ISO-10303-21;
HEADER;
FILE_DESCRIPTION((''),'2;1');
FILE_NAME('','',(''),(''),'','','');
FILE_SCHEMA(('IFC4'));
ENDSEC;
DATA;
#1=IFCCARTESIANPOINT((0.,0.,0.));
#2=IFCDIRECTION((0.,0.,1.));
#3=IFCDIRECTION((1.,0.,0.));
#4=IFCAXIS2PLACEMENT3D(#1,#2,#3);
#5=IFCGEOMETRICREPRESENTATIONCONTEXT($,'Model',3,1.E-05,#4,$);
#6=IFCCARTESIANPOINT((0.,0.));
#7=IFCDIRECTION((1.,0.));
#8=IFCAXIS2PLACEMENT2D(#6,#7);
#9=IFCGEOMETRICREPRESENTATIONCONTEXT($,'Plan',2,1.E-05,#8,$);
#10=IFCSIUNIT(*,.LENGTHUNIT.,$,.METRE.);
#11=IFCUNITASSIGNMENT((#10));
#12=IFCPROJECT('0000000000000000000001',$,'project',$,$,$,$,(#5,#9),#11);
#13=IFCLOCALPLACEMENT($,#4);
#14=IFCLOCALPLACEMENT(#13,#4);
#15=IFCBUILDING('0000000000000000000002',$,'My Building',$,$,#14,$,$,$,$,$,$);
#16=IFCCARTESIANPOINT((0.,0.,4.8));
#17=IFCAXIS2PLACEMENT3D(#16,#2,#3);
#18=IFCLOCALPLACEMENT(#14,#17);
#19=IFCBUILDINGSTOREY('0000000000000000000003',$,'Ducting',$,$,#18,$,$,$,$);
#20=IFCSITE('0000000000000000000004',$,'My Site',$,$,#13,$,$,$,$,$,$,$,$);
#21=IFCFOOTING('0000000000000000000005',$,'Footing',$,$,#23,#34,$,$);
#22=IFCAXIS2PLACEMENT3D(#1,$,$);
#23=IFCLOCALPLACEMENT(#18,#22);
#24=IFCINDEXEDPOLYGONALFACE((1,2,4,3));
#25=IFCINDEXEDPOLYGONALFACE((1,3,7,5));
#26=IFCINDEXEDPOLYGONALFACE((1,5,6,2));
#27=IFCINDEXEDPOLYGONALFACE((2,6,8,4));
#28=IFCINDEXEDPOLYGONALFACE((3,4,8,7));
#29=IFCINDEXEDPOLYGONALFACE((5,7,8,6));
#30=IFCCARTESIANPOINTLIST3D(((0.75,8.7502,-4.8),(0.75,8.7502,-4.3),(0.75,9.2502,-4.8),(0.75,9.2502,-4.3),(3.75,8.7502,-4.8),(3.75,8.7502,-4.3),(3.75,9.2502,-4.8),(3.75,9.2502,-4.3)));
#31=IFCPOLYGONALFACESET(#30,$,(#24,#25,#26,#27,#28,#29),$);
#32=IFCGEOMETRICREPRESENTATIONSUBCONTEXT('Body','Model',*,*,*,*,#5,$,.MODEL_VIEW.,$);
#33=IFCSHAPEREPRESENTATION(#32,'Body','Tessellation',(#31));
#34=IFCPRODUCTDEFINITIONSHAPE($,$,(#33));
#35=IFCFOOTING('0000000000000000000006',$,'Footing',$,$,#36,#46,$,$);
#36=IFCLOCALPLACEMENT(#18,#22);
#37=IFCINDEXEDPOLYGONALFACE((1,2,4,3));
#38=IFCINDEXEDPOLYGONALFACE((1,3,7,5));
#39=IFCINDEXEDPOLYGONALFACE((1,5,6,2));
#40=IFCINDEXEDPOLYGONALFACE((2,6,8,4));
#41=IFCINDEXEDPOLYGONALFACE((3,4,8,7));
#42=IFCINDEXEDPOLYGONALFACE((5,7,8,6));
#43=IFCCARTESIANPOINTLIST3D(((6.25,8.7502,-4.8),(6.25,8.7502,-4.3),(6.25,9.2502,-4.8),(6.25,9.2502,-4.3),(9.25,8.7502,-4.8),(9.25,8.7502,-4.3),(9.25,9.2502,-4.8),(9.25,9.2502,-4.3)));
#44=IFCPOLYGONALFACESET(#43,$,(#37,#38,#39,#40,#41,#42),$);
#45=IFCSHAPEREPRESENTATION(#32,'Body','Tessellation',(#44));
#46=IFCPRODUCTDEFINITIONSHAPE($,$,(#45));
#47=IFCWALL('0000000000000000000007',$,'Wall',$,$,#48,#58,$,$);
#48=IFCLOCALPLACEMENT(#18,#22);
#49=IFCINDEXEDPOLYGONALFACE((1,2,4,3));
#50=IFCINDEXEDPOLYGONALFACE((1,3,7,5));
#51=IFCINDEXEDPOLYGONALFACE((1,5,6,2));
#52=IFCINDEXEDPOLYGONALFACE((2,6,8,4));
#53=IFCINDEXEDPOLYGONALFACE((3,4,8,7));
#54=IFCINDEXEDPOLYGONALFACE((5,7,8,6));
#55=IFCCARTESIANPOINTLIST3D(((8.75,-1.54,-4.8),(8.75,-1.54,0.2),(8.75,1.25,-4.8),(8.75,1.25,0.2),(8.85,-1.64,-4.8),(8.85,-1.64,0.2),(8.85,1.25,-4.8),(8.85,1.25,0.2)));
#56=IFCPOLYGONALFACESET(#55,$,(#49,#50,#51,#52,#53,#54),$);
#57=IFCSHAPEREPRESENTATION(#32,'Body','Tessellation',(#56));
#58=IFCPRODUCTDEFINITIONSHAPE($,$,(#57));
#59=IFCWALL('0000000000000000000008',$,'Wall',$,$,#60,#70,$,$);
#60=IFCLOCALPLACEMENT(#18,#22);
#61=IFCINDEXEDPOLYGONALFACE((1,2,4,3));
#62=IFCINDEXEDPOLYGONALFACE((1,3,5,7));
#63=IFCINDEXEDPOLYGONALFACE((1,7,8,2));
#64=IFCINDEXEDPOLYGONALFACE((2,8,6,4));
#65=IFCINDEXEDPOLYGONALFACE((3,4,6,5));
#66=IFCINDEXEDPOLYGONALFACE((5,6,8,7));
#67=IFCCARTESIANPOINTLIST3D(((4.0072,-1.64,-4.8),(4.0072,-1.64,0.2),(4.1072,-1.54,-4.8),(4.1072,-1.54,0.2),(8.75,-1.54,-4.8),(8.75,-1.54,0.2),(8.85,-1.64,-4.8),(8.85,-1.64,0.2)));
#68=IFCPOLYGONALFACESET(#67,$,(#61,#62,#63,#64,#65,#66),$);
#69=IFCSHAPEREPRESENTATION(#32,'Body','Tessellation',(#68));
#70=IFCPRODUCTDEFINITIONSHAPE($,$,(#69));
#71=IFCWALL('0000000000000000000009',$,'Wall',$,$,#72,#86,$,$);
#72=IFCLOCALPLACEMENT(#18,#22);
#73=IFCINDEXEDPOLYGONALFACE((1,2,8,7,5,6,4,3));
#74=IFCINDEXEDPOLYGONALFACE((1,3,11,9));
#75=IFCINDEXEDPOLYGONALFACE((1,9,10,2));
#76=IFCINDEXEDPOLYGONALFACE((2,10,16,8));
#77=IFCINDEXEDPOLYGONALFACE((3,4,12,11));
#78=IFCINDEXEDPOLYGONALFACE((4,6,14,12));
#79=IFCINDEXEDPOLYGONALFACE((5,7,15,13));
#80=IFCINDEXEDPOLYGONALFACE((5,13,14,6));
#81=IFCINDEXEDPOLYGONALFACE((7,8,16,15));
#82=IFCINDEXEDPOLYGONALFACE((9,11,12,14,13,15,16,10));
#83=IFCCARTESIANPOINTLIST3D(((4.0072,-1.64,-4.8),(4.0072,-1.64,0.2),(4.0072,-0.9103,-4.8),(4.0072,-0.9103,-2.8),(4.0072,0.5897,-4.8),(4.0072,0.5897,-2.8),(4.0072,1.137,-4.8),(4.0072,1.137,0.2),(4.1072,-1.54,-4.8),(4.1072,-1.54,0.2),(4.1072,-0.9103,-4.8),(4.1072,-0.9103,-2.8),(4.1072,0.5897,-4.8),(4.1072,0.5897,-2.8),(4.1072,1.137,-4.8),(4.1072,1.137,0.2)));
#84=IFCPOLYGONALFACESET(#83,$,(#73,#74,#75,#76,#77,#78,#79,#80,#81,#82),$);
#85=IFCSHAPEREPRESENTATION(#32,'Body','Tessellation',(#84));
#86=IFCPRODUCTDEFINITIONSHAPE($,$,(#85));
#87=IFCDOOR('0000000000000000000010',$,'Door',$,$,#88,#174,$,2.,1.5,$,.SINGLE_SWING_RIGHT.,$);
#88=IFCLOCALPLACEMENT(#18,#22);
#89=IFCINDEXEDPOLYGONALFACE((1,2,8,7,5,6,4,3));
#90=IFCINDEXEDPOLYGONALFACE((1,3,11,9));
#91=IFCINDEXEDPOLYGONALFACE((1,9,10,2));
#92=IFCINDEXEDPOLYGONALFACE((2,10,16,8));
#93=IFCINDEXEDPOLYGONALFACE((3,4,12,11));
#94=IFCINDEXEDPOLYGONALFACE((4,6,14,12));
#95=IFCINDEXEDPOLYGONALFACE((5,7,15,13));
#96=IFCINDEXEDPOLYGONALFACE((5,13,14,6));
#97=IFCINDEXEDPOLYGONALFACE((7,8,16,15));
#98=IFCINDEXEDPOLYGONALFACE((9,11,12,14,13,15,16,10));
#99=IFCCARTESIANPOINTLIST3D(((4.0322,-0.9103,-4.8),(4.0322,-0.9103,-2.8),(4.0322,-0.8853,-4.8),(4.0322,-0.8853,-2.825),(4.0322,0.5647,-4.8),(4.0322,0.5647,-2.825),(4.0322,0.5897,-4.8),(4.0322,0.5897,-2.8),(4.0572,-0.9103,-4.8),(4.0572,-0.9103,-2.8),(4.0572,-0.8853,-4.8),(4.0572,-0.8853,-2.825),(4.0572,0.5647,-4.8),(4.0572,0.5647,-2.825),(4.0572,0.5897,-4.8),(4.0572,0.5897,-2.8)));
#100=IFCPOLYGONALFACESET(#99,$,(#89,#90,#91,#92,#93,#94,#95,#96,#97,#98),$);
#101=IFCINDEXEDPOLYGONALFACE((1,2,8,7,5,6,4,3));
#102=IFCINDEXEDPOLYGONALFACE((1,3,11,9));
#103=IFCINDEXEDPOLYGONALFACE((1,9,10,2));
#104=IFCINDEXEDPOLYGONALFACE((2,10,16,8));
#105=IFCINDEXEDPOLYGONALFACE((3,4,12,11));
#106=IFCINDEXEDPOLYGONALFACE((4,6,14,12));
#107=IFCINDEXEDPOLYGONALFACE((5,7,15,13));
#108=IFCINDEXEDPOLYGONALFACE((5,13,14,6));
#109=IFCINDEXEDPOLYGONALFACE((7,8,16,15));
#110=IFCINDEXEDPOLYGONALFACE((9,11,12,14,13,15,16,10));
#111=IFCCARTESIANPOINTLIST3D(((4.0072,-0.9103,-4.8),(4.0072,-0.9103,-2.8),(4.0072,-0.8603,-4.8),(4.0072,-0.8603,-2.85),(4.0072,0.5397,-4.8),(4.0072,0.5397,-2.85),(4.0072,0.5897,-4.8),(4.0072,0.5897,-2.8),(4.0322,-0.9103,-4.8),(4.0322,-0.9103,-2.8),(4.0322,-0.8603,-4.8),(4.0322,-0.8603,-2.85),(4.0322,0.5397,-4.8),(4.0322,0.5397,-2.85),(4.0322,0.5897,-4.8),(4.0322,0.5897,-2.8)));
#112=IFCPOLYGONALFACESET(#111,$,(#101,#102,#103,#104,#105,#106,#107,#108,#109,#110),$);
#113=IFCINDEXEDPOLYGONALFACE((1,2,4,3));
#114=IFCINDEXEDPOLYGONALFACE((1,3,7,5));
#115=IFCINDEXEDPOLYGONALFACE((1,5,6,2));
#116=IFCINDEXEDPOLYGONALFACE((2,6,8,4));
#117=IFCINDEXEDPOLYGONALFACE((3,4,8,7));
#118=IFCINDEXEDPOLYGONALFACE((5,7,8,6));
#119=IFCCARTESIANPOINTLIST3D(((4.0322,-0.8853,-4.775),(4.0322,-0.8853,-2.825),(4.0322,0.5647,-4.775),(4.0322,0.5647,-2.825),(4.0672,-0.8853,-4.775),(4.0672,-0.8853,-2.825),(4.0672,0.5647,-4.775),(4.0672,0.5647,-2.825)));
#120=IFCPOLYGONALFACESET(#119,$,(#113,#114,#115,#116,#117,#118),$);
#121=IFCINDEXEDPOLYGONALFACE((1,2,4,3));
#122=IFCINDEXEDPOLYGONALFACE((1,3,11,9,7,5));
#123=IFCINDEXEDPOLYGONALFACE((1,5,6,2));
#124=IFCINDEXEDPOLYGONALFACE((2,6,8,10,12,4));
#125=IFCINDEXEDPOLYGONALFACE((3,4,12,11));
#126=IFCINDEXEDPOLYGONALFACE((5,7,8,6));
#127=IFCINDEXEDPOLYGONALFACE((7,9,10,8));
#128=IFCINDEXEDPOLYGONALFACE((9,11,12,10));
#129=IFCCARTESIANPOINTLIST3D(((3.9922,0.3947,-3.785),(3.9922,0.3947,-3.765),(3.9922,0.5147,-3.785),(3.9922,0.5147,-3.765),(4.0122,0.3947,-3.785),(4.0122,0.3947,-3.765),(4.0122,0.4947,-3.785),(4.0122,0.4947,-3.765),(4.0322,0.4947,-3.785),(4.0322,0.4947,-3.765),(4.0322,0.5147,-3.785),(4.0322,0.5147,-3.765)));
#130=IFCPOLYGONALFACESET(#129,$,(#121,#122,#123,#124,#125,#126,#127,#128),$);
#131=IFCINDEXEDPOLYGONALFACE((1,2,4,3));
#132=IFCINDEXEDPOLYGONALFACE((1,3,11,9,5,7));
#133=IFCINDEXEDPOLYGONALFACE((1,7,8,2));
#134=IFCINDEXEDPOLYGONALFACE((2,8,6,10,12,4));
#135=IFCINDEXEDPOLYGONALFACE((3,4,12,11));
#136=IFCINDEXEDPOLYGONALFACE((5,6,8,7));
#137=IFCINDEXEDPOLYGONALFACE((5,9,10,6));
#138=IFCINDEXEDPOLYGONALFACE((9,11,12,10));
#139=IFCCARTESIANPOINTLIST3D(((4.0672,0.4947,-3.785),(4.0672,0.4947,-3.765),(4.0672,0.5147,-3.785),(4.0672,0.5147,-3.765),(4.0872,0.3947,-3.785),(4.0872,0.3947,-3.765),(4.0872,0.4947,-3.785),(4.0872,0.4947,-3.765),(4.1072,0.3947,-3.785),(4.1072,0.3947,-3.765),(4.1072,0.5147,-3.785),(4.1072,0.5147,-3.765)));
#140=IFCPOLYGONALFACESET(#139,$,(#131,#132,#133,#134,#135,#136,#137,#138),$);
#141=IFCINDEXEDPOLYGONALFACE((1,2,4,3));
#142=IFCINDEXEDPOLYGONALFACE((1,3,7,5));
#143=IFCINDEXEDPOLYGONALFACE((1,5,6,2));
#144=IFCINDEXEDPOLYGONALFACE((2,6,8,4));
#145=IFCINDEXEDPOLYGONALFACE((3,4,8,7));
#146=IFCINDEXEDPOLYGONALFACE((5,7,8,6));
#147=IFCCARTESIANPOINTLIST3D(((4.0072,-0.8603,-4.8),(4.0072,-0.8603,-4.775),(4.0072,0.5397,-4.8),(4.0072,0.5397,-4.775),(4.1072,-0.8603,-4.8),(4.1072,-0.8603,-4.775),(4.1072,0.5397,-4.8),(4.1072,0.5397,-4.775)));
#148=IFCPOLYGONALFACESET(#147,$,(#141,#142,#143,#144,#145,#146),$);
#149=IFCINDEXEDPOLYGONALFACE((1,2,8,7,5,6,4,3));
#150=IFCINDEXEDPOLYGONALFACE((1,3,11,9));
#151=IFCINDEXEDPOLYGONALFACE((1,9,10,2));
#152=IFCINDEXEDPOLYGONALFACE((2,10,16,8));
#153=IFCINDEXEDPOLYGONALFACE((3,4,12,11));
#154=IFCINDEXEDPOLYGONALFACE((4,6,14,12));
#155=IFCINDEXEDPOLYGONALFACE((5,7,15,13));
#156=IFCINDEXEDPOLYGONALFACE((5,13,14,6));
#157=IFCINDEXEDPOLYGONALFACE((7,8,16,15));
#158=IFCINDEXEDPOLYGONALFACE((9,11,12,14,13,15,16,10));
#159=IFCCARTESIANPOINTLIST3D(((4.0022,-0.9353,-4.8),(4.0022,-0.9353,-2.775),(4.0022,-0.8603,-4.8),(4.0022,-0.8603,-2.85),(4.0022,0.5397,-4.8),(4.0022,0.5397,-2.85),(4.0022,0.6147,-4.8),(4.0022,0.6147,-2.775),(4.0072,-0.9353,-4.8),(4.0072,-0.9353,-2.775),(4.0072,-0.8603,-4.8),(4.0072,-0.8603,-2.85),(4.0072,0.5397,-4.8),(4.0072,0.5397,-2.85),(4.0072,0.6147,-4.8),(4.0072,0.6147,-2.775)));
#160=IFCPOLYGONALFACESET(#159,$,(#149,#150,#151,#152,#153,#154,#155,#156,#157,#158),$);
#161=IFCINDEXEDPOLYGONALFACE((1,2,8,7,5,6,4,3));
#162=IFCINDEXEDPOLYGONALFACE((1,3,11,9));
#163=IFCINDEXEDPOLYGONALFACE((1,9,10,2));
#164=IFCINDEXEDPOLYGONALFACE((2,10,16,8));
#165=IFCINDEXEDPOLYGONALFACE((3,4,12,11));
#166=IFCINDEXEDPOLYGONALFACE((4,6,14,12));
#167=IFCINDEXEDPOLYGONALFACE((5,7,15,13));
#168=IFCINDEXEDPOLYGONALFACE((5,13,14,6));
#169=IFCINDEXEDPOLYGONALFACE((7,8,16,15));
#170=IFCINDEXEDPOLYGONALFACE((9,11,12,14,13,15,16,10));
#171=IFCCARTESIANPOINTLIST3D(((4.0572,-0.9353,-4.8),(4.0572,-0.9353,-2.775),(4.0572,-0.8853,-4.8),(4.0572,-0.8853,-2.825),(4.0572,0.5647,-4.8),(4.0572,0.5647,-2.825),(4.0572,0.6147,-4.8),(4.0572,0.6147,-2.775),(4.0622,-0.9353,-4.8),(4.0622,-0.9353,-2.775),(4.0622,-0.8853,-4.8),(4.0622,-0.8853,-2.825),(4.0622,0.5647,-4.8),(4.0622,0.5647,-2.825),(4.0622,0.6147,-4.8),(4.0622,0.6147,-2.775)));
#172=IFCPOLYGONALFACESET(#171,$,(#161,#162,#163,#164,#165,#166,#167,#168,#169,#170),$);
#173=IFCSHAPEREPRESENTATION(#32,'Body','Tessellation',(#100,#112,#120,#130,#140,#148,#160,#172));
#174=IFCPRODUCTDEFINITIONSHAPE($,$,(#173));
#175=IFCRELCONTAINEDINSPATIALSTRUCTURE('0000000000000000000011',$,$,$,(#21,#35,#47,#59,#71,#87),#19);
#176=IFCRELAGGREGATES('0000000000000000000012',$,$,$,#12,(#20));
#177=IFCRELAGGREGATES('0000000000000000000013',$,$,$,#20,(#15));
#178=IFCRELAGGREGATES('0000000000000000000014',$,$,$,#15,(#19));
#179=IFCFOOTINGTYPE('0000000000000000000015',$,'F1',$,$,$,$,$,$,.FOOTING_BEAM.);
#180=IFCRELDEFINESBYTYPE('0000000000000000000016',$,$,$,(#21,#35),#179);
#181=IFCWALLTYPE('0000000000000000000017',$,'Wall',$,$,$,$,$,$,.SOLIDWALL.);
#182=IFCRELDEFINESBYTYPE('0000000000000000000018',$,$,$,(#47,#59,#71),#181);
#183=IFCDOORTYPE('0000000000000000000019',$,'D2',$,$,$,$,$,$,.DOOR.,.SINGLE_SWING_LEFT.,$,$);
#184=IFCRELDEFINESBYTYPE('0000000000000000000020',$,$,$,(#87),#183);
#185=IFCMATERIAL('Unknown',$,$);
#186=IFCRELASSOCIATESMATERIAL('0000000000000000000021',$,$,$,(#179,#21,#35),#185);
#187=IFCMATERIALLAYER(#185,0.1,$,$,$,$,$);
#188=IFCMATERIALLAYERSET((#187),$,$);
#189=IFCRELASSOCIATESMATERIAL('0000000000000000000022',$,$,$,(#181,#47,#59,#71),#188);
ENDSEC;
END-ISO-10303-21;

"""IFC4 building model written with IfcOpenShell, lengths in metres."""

from ifc_helpers import new_model, entity, si_unit, frame, origin_with_axes, origin_2d_with_axis, place, context, subcontext, project, spatial, line, indexed_curve, rectangle, outline, extrude, shape, source, transform, mapped, material, layer, layer_set, layer_usage, material_profile, profile_set, profile_usage, type_object, type_shapes, element, fill, save


model = new_model("IFC4")

# Units and contexts
model_context = context("Model", 3, precision=1e-05, world=origin_with_axes())
plan_context = context("Plan", 2, precision=1e-05, world=origin_2d_with_axis())
body_context_1 = subcontext(model_context, "Body", "Model", "MODEL_VIEW")
body_context_2 = subcontext(plan_context, "Body", "Plan", "PLAN_VIEW")
ifc_project = project(units=[si_unit("LENGTHUNIT", "METRE")], contexts=[model_context, plan_context])

# Site, building, storey
site_placement = place(None, origin_with_axes())
site = spatial("IfcSite", under=ifc_project, at=site_placement, Name="My Site")
building_placement = place(site_placement, origin_with_axes())
building = spatial("IfcBuilding", under=site, at=building_placement, Name="My Building")
storey_placement = place(building_placement, frame((0.0, 0.0, 4.8), z_axis=(0.0, 0.0, 1.0), x_axis=(1.0, 0.0, 0.0)))
storey = spatial("IfcBuildingStorey", under=building, at=storey_placement, Name="Ducting")

# Footings
ifc_material = material(Name="Unknown")
ifc_material_profile_1 = material_profile(ifc_material, rectangle(XDim=0.5, YDim=0.5))
ifc_profile_set_1 = profile_set([ifc_material_profile_1])
ifc_profile_usage_1 = profile_usage(ifc_profile_set_1, cardinal=5)
footing_type = type_object("IfcFootingType", Name="F1", PredefinedType="FOOTING_BEAM", material=ifc_profile_set_1)
footing_1_placement = place(storey_placement, frame((0.75, 9.0002, -4.55), z_axis=(1.0, 0.0, 0.0), x_axis=(0.0, 1.0, 0.0)))
element("IfcFooting", 1, at=footing_1_placement, inside=storey, type_object=footing_type, material=ifc_profile_usage_1, Name="Footing", context=body_context_1, shape_type="SweptSolid", body=[
    extrude(rectangle(XDim=0.5, YDim=0.5), origin_with_axes(), (0.0, 0.0, 1.0), 3.0),
])
ifc_profile_usage_2 = profile_usage(ifc_profile_set_1, cardinal=5)
footing_2_placement = place(storey_placement, frame((6.25, 9.0002, -4.55), z_axis=(1.0, 0.0, 0.0), x_axis=(0.0, 1.0, 0.0)))
element("IfcFooting", 2, at=footing_2_placement, inside=storey, type_object=footing_type, material=ifc_profile_usage_2, Name="Footing", context=body_context_1, shape_type="SweptSolid", body=[
    extrude(rectangle(XDim=0.5, YDim=0.5), origin_with_axes(), (0.0, 0.0, 1.0), 3.0),
])

# Walls
ifc_layer = layer(ifc_material, 0.1)
ifc_layer_set = layer_set([ifc_layer])
ifc_layer_usage_1 = layer_usage(ifc_layer_set, "AXIS2", "POSITIVE", 0.0)
wall_type = type_object("IfcWallType", Name="Wall", PredefinedType="SOLIDWALL", material=ifc_layer_set)
wall_1_placement = place(storey_placement, frame((8.75, 1.25, -4.8), z_axis=(0.0, 0.0, 1.0), x_axis=(0.0, -1.0, 0.0)))
element("IfcWall", 3, at=wall_1_placement, inside=storey, type_object=wall_type, material=ifc_layer_usage_1, Name="Wall", context=body_context_1, shape_type="SweptSolid", body=[
    extrude(outline(indexed_curve([(0.0, 0.0), (0.0, 0.1), (2.89, 0.1), (2.79, 0.0)], segments=[line(1, 2, 3, 4, 1)])), origin_with_axes(), (0.0, 0.0, 1.0), 5.0),
])
ifc_layer_usage_2 = layer_usage(ifc_layer_set, "AXIS2", "POSITIVE", 0.0)
wall_2_placement = place(storey_placement, frame((8.75, -1.54, -4.8), z_axis=(0.0, 0.0, 1.0), x_axis=(-1.0, 0.0, 0.0)))
element("IfcWall", 4, at=wall_2_placement, inside=storey, type_object=wall_type, material=ifc_layer_usage_2, Name="Wall", context=body_context_1, shape_type="SweptSolid", body=[
    extrude(outline(indexed_curve([(0.0, 0.0), (-0.1, 0.1), (4.7428, 0.1), (4.6428, 0.0)], segments=[line(1, 2, 3, 4, 1)])), origin_with_axes(), (0.0, 0.0, 1.0), 5.0),
])

# Wall, opening, door
ifc_layer_usage_3 = layer_usage(ifc_layer_set, "AXIS2", "POSITIVE", 0.0)
wall_3_placement = place(storey_placement, frame((4.1072, -1.54, -4.8), z_axis=(0.0, 0.0, 1.0), x_axis=(0.0, 1.0, 0.0)))
wall_3 = element("IfcWall", 5, at=wall_3_placement, inside=storey, type_object=wall_type, material=ifc_layer_usage_3, Name="Wall", context=body_context_1, shape_type="SweptSolid", body=[
    extrude(outline(indexed_curve([(0.0, 0.0), (-0.1, 0.1), (2.677, 0.1), (2.677, 0.0)], segments=[line(1, 2, 3, 4, 1)])), origin_with_axes(), (0.0, 0.0, 1.0), 5.0),
])
shared_shape_1 = source(origin_with_axes(), body_context_1, "Body", "SweptSolid", [
    extrude(outline(indexed_curve([(0.0, 0.0), (1.5, 0.0), (1.5, 2.0), (0.0, 2.0)], segments=[line(1, 2, 3, 4, 1)])), frame((0.0, -0.6, 0.0), z_axis=(0.0, -1.0, 0.0), x_axis=(1.0, 0.0, 0.0)), (0.0, 0.0, -1.0), 1.2),
])
opening_placement = place(wall_3_placement, frame((2.1297, 0.1, 0.0), z_axis=(0.0, 0.0, 1.0), x_axis=(-1.0, 0.0, 0.0)))
opening = element("IfcOpeningElement", 6, at=opening_placement, cuts=wall_3, PredefinedType="OPENING", context=body_context_1, shape_type="MappedRepresentation", body=[
    mapped(shared_shape_1, transform((0.0, 0.0, 0.0), x_axis=(1.0, 0.0, 0.0), y_axis=(0.0, 1.0, 0.0), z_axis=(0.0, 0.0, 1.0), scale=1.0)),
])
door_type = type_object("IfcDoorType", Name="D2", OperationType="SINGLE_SWING_LEFT", PredefinedType="DOOR")
shared_shape_2 = source(origin_with_axes(), body_context_1, "Body", "SweptSolid", [
    extrude(outline(indexed_curve([(0.0, 0.0), (0.0, 2.0), (1.5, 2.0), (1.5, 0.0), (1.475, 0.0), (1.475, 1.975), (0.025, 1.975), (0.025, 0.0)], segments=[line(1, 2, 3, 4, 5, 6, 7, 8, 1)])), frame((0.0, 0.025, 0.0), z_axis=(0.0, -1.0, 0.0), x_axis=(1.0, 0.0, 0.0)), (0.0, 0.0, -1.0), 0.025),
    extrude(outline(indexed_curve([(0.0, 0.0), (0.0, 2.0), (1.5, 2.0), (1.5, 0.0), (1.45, 0.0), (1.45, 1.95), (0.05, 1.95), (0.05, 0.0)], segments=[line(1, 2, 3, 4, 5, 6, 7, 8, 1)])), frame((0.0, 0.0, 0.0), z_axis=(0.0, -1.0, 0.0), x_axis=(1.0, 0.0, 0.0)), (0.0, 0.0, -1.0), 0.025),
    extrude(outline(indexed_curve([(0.0, 0.0), (1.45, 0.0), (1.45, 0.035), (0.0, 0.035)], segments=[line(1, 2, 3, 4, 1)])), frame((0.025, 0.025, 0.025), z_axis=(0.0, 0.0, 1.0), x_axis=(1.0, 0.0, 0.0)), (0.0, 0.0, 1.0), 1.95),
    extrude(outline(indexed_curve([(0.0, 0.0), (0.0, -0.04), (0.12, -0.04), (0.12, -0.02), (0.02, -0.02), (0.02, 0.0)], segments=[line(1, 2, 3, 4, 5, 6, 1)])), frame((0.075, 0.025, 1.015), z_axis=(0.0, 0.0, 1.0), x_axis=(1.0, 0.0, 0.0)), (0.0, 0.0, 1.0), 0.02),
    extrude(outline(indexed_curve([(0.0, 0.0), (0.0, 0.04), (0.12, 0.04), (0.12, 0.02), (0.02, 0.02), (0.02, 0.0)], segments=[line(1, 2, 3, 4, 5, 6, 1)])), frame((0.075, 0.06, 1.015), z_axis=(0.0, 0.0, 1.0), x_axis=(1.0, 0.0, 0.0)), (0.0, 0.0, 1.0), 0.02),
    extrude(outline(indexed_curve([(0.0, 0.0), (1.4, 0.0), (1.4, 0.1), (0.0, 0.1)], segments=[line(1, 2, 3, 4, 1)])), frame((0.05, 0.0, 0.0), z_axis=(0.0, 0.0, 1.0), x_axis=(1.0, 0.0, 0.0)), (0.0, 0.0, 1.0), 0.025),
    extrude(outline(indexed_curve([(0.0, 0.0), (0.0, 2.025), (1.55, 2.025), (1.55, 0.0), (1.475, 0.0), (1.475, 1.95), (0.075, 1.95), (0.075, 0.0)], segments=[line(1, 2, 3, 4, 5, 6, 7, 8, 1)])), frame((-0.025, -0.005, 0.0), z_axis=(0.0, -1.0, 0.0), x_axis=(1.0, 0.0, 0.0)), (0.0, 0.0, -1.0), 0.005),
    extrude(outline(indexed_curve([(0.0, 0.0), (0.0, 2.025), (1.55, 2.025), (1.55, 0.0), (1.5, 0.0), (1.5, 1.975), (0.05, 1.975), (0.05, 0.0)], segments=[line(1, 2, 3, 4, 5, 6, 7, 8, 1)])), frame((-0.025, 0.05, 0.0), z_axis=(0.0, -1.0, 0.0), x_axis=(1.0, 0.0, 0.0)), (0.0, 0.0, -1.0), 0.005),
])
shared_shape_3 = source(origin_with_axes(), body_context_2, "Body", "Curve2D", [
    entity("IfcIndexedPolyCurve", entity("IfcCartesianPointList2D", [[0.0, 0.0], [0.0, 0.05], [0.025, 0.05], [0.025, 0.025], [0.05, 0.025], [0.05, 0.0]]), [entity("IfcLineIndex", [1, 2, 3, 4, 5, 6, 1])]),
    entity("IfcIndexedPolyCurve", entity("IfcCartesianPointList2D", [[1.5, 0.0], [1.5, 0.05], [1.475, 0.05], [1.475, 0.025], [1.45, 0.025], [1.45, 0.0]]), [entity("IfcLineIndex", [1, 2, 3, 4, 5, 6, 1])]),
    entity("IfcTrimmedCurve", entity("IfcEllipse", entity("IfcAxis2Placement2D", entity("IfcCartesianPoint", [1.44, 0.05]), entity("IfcDirection", [1.0, 0.0])), 1.415, 1.45), [entity("IfcCartesianPoint", [1.44, 1.5])], [entity("IfcCartesianPoint", [0.025, 0.05])], True, "CARTESIAN"),
    entity("IfcIndexedPolyCurve", entity("IfcCartesianPointList2D", [[1.475, 0.05], [1.44, 0.05], [1.44, 1.5], [1.475, 1.5]]), [entity("IfcLineIndex", [1, 2, 3, 4, 1])]),
])
type_shapes(door_type, [shared_shape_2, shared_shape_3])
door_placement = place(opening_placement, frame((0.0, 0.0, 0.0), z_axis=(0.0, 0.0, 1.0), x_axis=(1.0, 0.0, 0.0)))
door = element("IfcDoor", 7, at=door_placement, inside=storey, type_object=door_type, Name="Door", OperationType="SINGLE_SWING_RIGHT", OverallHeight=2.0, OverallWidth=1.5, shapes=[
    shape(body_context_1, "Body", "MappedRepresentation", [mapped(shared_shape_2, transform((0.0, 0.0, 0.0), x_axis=(1.0, 0.0, 0.0), y_axis=(0.0, 1.0, 0.0), z_axis=(0.0, 0.0, 1.0), scale=1.0))]),
    shape(body_context_2, "Body", "MappedRepresentation", [mapped(shared_shape_3, transform((0.0, 0.0, 0.0), x_axis=(1.0, 0.0, 0.0), y_axis=(0.0, 1.0, 0.0), z_axis=(0.0, 0.0, 1.0), scale=1.0))]),
])
fill(opening, door)

save(model, "model.ifc")
